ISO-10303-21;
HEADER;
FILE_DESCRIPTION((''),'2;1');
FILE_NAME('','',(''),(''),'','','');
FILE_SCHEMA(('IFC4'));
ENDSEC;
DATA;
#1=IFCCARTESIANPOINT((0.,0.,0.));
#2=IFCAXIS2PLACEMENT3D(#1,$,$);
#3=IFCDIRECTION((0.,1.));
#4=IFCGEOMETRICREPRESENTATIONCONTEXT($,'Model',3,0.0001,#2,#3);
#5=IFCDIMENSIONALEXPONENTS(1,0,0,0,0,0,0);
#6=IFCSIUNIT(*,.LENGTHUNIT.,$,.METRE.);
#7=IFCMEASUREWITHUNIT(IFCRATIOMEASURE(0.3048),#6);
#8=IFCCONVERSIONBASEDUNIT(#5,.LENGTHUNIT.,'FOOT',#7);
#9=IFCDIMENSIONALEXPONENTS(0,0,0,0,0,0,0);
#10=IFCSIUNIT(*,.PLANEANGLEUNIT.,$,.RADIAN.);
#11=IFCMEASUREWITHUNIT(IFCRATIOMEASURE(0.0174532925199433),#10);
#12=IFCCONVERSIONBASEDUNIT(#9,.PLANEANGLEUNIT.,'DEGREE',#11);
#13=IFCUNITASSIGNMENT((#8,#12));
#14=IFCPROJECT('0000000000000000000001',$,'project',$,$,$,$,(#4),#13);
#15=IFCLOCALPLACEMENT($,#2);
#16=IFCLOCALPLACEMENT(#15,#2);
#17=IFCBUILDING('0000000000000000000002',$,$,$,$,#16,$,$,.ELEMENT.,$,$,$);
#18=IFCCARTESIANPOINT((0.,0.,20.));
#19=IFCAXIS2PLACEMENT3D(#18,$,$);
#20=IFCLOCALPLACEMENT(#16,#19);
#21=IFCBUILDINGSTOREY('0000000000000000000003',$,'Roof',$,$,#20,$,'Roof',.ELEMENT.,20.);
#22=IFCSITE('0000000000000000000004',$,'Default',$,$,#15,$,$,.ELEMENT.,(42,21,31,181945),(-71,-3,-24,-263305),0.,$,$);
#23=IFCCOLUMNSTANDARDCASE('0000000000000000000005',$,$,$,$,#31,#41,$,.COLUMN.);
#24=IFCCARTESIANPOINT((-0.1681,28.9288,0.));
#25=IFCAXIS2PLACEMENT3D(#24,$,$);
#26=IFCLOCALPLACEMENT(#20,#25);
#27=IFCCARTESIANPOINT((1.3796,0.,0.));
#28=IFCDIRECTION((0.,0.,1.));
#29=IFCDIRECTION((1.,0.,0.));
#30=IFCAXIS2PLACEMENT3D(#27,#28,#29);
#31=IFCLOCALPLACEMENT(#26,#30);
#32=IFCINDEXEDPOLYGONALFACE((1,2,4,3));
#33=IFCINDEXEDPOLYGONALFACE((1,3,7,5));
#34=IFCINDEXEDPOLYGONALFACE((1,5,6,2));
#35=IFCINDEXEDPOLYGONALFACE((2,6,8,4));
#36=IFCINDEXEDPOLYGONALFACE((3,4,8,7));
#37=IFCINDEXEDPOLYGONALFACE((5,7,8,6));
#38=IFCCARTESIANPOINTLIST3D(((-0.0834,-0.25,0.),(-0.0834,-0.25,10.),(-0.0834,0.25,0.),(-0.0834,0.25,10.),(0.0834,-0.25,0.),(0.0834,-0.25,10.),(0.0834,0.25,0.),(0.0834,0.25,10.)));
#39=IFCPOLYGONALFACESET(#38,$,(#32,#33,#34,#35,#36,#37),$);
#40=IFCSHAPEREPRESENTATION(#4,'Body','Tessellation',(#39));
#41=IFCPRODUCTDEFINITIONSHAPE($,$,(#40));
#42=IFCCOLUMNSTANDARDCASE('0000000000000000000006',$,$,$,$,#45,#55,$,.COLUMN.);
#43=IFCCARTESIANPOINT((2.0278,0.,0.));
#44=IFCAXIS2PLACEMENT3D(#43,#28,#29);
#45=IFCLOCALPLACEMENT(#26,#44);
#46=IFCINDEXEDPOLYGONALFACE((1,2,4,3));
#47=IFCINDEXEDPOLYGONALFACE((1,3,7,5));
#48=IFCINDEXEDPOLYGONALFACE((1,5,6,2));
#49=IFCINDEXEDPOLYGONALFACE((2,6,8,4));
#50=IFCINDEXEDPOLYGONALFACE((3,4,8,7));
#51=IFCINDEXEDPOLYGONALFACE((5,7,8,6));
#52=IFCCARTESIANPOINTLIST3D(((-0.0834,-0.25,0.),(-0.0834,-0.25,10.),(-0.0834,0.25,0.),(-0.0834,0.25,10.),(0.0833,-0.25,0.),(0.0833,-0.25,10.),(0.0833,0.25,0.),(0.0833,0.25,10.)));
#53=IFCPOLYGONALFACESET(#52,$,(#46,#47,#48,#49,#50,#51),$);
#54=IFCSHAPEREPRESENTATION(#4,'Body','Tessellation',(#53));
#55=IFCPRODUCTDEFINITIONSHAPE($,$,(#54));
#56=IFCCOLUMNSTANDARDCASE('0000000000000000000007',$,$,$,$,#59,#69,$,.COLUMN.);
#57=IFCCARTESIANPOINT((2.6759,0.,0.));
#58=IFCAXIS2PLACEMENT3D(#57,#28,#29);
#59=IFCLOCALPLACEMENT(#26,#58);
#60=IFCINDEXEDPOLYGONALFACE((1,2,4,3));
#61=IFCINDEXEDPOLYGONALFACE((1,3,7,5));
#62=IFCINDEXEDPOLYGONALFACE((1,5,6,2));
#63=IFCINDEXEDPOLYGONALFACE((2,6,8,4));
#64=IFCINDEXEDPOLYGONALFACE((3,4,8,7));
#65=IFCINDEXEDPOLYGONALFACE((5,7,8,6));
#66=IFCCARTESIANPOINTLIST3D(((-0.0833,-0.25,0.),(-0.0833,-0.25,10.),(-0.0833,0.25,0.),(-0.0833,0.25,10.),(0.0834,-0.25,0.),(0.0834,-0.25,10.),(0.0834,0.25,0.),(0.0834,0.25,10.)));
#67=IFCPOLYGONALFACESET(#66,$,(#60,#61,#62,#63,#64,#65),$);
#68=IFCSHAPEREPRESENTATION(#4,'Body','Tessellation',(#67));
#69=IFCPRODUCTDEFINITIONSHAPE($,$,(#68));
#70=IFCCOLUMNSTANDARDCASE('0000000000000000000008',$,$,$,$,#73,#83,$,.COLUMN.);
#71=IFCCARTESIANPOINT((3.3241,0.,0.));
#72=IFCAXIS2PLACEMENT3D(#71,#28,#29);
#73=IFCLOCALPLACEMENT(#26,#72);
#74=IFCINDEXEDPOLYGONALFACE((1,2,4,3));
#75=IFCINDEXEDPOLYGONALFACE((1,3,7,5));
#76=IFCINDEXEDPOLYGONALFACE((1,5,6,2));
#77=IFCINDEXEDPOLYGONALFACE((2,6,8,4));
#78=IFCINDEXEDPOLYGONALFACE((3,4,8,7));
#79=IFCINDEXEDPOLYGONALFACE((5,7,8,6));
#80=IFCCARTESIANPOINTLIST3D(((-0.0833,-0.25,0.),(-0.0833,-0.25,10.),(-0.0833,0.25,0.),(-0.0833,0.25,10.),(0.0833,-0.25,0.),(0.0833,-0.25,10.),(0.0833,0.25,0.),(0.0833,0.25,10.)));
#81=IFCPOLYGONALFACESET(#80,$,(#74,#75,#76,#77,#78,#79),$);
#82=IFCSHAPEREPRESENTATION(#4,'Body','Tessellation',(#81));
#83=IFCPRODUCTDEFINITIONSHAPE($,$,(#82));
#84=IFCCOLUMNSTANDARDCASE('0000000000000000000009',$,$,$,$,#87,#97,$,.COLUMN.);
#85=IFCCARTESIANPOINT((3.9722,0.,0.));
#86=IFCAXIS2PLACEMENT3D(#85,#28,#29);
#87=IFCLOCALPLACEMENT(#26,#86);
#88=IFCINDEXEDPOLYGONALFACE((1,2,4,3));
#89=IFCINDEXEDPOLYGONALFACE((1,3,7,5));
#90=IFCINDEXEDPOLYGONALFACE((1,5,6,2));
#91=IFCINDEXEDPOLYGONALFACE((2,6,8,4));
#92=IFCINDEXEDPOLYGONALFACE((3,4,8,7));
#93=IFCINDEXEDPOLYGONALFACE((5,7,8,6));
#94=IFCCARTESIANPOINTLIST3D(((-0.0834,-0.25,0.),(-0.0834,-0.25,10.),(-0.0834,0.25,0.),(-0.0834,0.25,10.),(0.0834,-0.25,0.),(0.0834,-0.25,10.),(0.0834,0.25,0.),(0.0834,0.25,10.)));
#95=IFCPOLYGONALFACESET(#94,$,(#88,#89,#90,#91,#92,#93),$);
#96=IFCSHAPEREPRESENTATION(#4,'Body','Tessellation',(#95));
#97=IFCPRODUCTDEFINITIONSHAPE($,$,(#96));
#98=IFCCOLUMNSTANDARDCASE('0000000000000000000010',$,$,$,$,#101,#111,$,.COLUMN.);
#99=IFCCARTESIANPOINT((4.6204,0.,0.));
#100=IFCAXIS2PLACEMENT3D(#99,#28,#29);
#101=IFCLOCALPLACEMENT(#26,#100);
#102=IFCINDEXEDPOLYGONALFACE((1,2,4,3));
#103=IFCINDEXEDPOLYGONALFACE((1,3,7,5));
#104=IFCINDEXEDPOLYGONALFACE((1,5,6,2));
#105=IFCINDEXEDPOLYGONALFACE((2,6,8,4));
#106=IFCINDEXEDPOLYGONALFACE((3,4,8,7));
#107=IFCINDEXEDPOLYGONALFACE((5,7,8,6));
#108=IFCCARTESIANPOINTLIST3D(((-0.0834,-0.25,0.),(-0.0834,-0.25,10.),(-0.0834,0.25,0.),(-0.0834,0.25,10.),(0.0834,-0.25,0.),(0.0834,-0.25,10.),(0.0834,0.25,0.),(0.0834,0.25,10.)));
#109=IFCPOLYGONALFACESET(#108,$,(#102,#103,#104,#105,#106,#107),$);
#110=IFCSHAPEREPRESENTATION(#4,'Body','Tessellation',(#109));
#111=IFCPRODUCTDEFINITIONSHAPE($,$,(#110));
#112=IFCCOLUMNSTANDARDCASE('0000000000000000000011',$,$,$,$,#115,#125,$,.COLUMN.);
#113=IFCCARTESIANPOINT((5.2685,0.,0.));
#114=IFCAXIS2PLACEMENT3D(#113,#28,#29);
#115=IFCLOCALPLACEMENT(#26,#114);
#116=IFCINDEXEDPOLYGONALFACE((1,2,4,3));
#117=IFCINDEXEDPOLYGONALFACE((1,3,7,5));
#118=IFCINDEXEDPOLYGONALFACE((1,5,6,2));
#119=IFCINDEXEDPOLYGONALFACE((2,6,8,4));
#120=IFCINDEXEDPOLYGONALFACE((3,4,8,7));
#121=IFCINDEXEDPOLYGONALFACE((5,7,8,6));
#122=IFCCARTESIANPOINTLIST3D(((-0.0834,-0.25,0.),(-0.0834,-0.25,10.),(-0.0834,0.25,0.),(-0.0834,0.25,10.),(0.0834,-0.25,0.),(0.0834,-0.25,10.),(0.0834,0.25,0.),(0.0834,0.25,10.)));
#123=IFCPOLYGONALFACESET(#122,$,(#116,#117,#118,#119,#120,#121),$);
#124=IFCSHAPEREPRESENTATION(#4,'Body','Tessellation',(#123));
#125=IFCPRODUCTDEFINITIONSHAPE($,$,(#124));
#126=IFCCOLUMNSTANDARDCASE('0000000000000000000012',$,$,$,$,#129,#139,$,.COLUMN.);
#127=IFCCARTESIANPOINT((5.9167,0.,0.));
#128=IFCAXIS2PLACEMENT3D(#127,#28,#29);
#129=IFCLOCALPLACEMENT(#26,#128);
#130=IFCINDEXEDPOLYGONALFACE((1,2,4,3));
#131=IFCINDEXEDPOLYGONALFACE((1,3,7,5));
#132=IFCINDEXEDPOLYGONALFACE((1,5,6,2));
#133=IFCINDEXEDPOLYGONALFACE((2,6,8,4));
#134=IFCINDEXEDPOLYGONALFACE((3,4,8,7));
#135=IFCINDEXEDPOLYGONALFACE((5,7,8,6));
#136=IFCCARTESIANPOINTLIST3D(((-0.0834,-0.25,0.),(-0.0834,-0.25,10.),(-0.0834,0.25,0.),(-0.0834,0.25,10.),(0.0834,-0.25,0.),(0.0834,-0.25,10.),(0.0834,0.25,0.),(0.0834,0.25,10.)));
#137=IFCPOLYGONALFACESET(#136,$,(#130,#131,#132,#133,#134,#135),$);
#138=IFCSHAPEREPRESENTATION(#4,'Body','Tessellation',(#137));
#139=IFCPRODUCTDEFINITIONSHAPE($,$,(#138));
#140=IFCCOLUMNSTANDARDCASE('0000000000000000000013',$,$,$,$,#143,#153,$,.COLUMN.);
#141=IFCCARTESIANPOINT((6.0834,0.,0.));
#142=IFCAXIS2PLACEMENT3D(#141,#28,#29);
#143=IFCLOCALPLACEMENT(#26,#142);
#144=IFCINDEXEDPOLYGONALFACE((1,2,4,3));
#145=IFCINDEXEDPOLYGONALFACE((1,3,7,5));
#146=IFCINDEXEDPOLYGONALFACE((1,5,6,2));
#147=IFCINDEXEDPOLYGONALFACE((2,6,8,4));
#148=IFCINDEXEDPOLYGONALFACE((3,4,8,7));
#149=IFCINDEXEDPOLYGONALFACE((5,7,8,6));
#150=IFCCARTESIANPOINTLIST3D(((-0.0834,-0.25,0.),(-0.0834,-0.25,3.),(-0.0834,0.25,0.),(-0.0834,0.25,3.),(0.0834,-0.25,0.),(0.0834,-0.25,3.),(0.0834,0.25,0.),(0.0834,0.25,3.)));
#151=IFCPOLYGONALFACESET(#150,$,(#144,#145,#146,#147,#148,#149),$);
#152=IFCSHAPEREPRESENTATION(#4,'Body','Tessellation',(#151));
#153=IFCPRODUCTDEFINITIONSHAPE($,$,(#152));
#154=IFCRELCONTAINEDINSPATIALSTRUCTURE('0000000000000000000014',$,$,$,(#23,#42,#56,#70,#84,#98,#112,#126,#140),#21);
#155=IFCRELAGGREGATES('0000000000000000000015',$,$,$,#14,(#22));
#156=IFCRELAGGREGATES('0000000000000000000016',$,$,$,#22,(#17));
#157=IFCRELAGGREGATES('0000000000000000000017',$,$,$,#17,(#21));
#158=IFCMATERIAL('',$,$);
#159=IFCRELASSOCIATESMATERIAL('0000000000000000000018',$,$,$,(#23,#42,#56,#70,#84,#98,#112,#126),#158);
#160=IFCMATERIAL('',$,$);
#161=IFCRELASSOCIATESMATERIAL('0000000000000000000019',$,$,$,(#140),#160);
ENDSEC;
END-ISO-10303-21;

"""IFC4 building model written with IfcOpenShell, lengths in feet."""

from ifc_helpers import new_model, entity, si_unit, converted_unit, direction, frame, origin, place, context, project, spatial, rectangle, extrude, material, element, save


model = new_model("IFC4")

# Units and contexts
model_context = context("Model", 3, precision=0.0001, world=origin(), true_north=direction((0.0, 1.0)))
ifc_project = project(units=[converted_unit("LENGTHUNIT", "FOOT", entity("IfcRatioMeasure", 0.3048), si_unit("LENGTHUNIT", "METRE"), dimensions=[1, 0, 0, 0, 0, 0, 0]), converted_unit("PLANEANGLEUNIT", "DEGREE", entity("IfcRatioMeasure", 0.0174532925199433), si_unit("PLANEANGLEUNIT", "RADIAN"), dimensions=[0, 0, 0, 0, 0, 0, 0])], contexts=[model_context])

# Site, building, storey
site_placement = place(None, origin())
site = spatial("IfcSite", under=ifc_project, at=site_placement, Name="Default", CompositionType="ELEMENT", RefLatitude=(42, 21, 31, 181945), RefLongitude=(-71, -3, -24, -263305), RefElevation=0.0)
building_placement = place(site_placement, origin())
building = spatial("IfcBuilding", under=site, at=building_placement, CompositionType="ELEMENT")
storey_placement = place(building_placement, frame((0.0, 0.0, 20.0)))
storey = spatial("IfcBuildingStorey", under=building, at=storey_placement, Name="Roof", LongName="Roof", CompositionType="ELEMENT", Elevation=20.0)

# Columns
ifc_material_1 = material(Name="")
placement = place(storey_placement, frame((-0.1681, 28.9288, 0.0)))
for number, where, z_axis, x_axis in (
    (1, (1.3796, 0.0, 0.0), (0.0, 0.0, 1.0), (1.0, 0.0, 0.0)),
    (2, (2.0278, 0.0, 0.0), (0.0, 0.0, 1.0), (1.0, 0.0, 0.0)),
    (3, (2.6759, 0.0, 0.0), (0.0, 0.0, 1.0), (1.0, 0.0, 0.0)),
    (4, (3.3241, 0.0, 0.0), (0.0, 0.0, 1.0), (1.0, 0.0, 0.0)),
    (5, (3.9722, 0.0, 0.0), (0.0, 0.0, 1.0), (1.0, 0.0, 0.0)),
    (6, (4.6204, 0.0, 0.0), (0.0, 0.0, 1.0), (1.0, 0.0, 0.0)),
    (7, (5.2685, 0.0, 0.0), (0.0, 0.0, 1.0), (1.0, 0.0, 0.0)),
    (8, (5.9167, 0.0, 0.0), (0.0, 0.0, 1.0), (1.0, 0.0, 0.0)),
):
    element("IfcColumnStandardCase", number, at=place(placement, frame(where, z_axis=z_axis, x_axis=x_axis)), inside=storey, material=ifc_material_1, PredefinedType="COLUMN", context=model_context, shape_type="SweptSolid", body=[
        extrude(rectangle(XDim=0.1667, YDim=0.5), origin(), (0.0, 0.0, 1.0), 10.0),
    ])
ifc_material_2 = material(Name="")
for number, where, z_axis, x_axis in (
    (9, (6.0834, 0.0, 0.0), (0.0, 0.0, 1.0), (1.0, 0.0, 0.0)),
):
    element("IfcColumnStandardCase", number, at=place(placement, frame(where, z_axis=z_axis, x_axis=x_axis)), inside=storey, material=ifc_material_2, PredefinedType="COLUMN", context=model_context, shape_type="SweptSolid", body=[
        extrude(rectangle(XDim=0.1667, YDim=0.5), origin(), (0.0, 0.0, 1.0), 3.0),
    ])

save(model, "model.ifc")
